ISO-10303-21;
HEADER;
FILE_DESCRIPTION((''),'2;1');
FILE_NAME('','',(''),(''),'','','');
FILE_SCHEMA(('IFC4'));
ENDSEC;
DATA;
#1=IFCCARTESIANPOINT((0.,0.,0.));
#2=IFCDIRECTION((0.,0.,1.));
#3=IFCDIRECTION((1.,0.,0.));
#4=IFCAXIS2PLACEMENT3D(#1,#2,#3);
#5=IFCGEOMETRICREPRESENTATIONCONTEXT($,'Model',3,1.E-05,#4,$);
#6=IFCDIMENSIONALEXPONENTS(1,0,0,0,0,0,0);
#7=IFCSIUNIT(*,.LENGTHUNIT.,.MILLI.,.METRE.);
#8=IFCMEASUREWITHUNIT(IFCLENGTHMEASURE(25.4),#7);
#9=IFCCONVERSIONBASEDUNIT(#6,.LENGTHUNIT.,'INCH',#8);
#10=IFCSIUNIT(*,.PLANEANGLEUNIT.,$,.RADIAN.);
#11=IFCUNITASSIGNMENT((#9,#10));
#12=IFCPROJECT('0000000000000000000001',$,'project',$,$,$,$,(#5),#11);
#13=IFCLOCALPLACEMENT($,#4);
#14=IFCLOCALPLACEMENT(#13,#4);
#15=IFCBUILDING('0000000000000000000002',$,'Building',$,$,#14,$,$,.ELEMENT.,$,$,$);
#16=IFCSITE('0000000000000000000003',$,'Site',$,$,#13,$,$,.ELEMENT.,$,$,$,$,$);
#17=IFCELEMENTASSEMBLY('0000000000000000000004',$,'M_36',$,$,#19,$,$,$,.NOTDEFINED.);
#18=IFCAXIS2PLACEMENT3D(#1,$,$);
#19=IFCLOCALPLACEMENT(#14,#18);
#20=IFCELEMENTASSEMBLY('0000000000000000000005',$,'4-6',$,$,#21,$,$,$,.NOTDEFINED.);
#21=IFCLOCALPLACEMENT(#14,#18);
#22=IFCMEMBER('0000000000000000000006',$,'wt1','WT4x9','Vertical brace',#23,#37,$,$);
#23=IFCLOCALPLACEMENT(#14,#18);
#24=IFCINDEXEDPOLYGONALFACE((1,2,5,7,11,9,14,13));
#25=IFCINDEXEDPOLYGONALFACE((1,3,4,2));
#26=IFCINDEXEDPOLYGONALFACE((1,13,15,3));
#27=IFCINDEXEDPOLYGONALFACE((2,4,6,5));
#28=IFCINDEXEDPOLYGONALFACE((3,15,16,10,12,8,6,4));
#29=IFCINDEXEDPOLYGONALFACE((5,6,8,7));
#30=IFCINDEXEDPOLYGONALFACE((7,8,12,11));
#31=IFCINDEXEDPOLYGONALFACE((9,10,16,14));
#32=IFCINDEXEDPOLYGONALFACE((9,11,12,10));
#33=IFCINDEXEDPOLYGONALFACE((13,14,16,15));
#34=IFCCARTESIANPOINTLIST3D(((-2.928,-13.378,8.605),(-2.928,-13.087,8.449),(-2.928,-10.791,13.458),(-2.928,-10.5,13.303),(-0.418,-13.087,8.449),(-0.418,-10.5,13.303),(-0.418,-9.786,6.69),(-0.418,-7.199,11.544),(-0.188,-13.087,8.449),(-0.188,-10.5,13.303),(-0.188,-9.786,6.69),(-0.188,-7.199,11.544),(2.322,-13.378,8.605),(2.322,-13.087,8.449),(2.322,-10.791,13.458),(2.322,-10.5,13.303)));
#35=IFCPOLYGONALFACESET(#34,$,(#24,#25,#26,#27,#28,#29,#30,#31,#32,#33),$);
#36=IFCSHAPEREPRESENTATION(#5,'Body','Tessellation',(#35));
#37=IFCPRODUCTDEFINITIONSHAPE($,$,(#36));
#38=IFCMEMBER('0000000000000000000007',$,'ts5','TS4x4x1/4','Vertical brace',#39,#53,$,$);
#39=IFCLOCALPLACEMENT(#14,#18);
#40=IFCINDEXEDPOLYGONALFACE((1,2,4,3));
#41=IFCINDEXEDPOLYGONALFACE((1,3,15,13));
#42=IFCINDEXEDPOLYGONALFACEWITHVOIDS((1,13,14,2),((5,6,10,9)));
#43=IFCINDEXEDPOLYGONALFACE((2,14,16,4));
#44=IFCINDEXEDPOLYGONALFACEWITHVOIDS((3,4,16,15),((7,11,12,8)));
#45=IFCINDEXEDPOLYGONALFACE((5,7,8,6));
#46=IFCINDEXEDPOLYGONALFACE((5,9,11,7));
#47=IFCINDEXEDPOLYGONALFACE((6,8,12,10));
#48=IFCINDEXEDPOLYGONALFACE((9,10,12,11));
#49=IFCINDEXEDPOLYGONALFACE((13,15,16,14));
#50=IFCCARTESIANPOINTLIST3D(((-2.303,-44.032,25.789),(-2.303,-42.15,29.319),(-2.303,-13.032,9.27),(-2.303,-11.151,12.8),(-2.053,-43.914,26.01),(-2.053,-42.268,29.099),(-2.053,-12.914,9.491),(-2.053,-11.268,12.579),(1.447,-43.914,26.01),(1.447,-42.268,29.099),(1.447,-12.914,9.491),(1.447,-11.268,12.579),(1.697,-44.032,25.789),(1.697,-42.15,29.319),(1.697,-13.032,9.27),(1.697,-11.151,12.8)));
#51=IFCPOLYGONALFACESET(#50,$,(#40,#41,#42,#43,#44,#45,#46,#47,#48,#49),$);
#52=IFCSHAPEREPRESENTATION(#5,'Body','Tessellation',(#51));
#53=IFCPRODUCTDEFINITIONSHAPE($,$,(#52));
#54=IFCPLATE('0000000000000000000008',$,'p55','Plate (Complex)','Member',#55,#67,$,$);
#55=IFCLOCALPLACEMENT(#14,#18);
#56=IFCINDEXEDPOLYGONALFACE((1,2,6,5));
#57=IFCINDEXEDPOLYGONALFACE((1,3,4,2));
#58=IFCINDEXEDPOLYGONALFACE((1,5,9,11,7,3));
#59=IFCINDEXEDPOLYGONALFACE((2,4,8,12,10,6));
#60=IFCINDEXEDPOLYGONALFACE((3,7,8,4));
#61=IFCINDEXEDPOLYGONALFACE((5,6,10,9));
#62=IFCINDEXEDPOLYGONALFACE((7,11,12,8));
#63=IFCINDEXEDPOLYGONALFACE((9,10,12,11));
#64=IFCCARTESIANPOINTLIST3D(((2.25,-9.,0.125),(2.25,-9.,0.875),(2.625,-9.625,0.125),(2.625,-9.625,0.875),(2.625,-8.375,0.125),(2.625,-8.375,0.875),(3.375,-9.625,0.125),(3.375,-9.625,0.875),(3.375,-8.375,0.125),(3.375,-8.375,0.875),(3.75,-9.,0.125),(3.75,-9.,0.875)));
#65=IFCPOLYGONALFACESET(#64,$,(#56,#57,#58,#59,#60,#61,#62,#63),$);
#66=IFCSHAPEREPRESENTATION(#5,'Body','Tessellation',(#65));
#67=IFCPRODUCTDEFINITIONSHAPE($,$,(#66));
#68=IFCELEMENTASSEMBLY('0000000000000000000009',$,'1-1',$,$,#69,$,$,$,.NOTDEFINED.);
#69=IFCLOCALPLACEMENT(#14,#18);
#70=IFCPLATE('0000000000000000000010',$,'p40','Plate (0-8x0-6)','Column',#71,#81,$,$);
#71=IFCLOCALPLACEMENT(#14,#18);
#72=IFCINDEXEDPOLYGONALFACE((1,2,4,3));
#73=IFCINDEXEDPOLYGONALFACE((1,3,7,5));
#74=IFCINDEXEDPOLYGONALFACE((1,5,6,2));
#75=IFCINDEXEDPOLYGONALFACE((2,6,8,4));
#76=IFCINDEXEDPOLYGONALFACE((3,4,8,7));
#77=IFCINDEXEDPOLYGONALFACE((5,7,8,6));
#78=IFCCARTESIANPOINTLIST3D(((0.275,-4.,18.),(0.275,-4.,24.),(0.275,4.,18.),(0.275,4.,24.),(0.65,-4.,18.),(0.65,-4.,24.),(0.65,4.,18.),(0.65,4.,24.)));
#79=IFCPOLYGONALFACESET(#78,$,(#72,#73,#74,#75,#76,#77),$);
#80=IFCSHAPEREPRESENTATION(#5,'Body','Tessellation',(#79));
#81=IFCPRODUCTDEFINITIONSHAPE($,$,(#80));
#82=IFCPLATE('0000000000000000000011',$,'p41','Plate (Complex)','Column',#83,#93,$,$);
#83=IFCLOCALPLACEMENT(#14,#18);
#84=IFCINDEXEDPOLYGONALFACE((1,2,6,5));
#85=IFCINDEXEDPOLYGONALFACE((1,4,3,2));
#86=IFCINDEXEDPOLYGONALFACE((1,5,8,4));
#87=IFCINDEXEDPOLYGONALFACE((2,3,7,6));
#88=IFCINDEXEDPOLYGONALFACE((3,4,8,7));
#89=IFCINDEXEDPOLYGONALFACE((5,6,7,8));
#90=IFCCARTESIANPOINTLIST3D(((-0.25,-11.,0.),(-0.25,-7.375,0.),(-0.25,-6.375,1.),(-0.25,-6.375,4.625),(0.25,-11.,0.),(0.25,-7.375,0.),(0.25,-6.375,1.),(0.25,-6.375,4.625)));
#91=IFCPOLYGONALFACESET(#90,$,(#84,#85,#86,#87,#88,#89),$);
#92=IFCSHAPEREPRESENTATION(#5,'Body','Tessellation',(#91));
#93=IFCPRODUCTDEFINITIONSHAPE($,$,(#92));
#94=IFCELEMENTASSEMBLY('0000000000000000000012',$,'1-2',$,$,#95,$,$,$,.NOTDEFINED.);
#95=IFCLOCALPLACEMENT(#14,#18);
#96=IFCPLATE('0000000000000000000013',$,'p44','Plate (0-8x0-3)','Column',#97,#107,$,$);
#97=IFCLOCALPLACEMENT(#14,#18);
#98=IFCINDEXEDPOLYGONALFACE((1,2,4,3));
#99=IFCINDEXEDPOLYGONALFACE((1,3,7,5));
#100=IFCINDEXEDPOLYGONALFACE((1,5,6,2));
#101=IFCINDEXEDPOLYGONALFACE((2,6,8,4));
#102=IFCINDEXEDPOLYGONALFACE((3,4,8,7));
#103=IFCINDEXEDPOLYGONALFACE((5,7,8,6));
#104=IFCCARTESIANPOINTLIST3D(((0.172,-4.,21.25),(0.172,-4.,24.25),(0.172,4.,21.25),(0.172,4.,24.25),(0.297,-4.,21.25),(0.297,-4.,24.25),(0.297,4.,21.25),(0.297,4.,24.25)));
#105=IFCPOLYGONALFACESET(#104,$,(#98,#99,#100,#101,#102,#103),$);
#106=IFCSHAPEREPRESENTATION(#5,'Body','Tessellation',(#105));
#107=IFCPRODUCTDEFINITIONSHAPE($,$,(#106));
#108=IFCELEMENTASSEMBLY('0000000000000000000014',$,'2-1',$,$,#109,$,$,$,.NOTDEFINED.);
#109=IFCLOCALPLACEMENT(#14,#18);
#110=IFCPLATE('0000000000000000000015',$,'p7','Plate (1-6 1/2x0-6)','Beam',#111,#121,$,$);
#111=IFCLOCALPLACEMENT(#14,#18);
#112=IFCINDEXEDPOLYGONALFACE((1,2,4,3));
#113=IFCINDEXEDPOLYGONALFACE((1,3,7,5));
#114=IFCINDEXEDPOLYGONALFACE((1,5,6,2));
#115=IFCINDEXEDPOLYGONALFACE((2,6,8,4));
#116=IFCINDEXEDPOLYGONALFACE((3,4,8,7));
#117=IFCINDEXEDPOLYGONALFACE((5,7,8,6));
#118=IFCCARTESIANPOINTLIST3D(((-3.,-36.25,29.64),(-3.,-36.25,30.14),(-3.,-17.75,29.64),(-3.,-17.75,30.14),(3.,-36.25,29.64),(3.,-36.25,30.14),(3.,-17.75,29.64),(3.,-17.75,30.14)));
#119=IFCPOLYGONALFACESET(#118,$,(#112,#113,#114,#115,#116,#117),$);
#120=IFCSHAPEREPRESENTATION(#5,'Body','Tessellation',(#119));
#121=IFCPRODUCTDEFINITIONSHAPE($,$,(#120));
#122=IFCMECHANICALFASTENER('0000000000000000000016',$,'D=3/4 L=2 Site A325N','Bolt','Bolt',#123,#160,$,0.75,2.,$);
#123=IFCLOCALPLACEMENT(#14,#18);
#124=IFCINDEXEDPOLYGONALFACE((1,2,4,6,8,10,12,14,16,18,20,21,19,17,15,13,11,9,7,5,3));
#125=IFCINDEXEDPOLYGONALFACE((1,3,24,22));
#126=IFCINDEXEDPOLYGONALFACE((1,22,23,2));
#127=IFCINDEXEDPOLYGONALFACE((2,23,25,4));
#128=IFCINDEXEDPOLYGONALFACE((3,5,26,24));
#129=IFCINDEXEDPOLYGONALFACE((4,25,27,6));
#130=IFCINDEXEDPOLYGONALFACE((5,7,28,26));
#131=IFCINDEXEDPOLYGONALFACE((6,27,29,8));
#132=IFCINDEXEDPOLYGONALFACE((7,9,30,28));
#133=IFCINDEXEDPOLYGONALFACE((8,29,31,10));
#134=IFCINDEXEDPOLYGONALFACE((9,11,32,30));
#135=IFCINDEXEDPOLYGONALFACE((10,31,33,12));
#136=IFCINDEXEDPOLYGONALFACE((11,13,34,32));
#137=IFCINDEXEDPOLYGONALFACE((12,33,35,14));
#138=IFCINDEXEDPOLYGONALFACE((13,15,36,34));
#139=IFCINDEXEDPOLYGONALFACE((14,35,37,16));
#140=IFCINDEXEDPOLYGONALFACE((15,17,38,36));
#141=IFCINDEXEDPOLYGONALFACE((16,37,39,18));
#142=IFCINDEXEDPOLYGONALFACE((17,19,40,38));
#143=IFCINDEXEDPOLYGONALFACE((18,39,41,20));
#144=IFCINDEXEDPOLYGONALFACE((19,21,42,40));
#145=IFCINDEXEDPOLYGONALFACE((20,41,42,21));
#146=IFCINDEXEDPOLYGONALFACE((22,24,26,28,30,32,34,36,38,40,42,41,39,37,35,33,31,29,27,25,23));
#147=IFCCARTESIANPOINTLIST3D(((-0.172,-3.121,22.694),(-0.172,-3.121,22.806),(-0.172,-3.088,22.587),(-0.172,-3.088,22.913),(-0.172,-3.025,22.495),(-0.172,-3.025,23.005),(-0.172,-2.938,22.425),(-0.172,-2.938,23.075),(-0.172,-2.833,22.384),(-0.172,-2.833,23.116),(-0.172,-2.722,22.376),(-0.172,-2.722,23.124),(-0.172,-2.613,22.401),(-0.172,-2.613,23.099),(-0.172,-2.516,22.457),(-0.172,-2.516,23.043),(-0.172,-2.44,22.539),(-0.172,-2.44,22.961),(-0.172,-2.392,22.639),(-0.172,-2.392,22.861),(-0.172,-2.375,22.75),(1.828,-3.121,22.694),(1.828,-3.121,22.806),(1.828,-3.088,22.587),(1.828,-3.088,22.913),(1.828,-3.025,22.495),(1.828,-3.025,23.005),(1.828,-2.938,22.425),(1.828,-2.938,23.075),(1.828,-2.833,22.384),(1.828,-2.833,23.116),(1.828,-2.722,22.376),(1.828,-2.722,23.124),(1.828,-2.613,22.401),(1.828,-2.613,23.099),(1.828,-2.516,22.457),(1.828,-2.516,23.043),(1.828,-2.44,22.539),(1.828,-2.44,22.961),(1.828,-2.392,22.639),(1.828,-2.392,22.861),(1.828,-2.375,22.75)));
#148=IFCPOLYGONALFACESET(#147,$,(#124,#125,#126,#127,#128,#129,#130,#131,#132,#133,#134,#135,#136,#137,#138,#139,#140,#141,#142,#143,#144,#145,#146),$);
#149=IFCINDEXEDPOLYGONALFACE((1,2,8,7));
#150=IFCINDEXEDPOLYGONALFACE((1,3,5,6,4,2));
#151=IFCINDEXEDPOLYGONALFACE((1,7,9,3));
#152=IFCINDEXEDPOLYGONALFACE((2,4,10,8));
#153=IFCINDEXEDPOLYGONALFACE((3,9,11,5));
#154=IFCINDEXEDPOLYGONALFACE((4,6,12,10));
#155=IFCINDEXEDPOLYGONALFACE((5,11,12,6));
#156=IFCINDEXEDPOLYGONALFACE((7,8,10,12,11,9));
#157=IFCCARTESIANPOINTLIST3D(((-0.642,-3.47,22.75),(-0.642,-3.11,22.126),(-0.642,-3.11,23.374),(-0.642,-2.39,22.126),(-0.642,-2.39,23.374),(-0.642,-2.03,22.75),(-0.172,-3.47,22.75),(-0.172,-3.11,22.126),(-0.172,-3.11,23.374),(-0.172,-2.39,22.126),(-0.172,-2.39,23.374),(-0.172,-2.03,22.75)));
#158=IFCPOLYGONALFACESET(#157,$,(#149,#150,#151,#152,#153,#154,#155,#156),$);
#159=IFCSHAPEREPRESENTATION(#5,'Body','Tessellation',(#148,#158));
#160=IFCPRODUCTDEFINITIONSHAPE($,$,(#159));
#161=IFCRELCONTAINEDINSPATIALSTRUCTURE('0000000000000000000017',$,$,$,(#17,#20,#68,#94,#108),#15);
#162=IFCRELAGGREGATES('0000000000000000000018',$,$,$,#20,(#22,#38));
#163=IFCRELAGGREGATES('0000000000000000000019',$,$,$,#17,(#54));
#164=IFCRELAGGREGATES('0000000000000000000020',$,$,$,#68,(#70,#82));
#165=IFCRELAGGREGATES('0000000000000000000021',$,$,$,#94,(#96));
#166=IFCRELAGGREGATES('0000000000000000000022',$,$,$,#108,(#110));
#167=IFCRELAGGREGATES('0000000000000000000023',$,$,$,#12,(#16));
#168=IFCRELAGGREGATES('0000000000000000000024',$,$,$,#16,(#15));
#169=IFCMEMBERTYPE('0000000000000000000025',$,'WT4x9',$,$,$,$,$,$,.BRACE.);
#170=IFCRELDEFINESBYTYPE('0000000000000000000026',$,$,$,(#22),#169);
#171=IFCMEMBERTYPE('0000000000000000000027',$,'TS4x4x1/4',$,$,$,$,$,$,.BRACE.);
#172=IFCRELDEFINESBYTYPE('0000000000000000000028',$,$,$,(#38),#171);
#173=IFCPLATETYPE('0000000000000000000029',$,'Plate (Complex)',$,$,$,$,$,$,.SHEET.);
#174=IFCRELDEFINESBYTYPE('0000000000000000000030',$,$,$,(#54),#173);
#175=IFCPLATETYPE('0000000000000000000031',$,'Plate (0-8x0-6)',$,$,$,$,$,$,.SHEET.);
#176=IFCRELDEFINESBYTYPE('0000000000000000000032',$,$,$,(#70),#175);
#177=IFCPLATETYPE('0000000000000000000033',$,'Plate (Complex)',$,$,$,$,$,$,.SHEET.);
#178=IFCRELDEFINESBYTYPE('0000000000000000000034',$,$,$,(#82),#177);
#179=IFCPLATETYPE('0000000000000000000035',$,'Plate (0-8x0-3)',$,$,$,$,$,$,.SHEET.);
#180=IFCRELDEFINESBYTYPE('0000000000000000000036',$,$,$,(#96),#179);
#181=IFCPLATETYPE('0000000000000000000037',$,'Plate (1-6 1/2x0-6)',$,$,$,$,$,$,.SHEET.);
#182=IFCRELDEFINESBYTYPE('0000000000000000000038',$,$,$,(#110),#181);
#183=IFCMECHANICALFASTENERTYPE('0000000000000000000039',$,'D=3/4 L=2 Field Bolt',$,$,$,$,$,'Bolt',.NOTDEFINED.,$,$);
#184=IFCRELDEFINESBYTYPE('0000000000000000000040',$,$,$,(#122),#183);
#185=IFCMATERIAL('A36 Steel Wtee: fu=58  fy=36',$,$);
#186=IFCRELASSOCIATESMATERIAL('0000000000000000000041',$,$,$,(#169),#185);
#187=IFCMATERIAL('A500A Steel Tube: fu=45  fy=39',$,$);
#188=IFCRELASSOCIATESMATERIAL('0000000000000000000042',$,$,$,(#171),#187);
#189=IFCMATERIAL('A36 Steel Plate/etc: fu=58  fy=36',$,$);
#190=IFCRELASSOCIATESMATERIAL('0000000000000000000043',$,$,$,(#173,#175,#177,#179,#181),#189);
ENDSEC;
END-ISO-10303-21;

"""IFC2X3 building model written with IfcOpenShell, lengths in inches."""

from ifc_helpers import new_model, entity, si_unit, converted_unit, frame, frame_2d, origin_with_axes, origin_2d_with_axis, place, context, project, spatial, polyline, hollow_rectangle, circle, t_section, outline, extrude, source, transform, mapped, material, type_object, type_shapes, element, aggregate, save


model = new_model("IFC2X3")

# Units and contexts
model_context = context("Model", 3, precision=1e-05, world=origin_with_axes())
ifc_project = project(units=[converted_unit("LENGTHUNIT", "INCH", entity("IfcLengthMeasure", 25.4), si_unit("LENGTHUNIT", "METRE", prefix="MILLI"), dimensions=[1, 0, 0, 0, 0, 0, 0]), si_unit("PLANEANGLEUNIT", "RADIAN")], contexts=[model_context])

# Site, building
site_placement = place(None, origin_with_axes())
site = spatial("IfcSite", under=ifc_project, at=site_placement, Name="Site", CompositionType="ELEMENT")
building_placement = place(site_placement, origin_with_axes())
building = spatial("IfcBuilding", under=site, at=building_placement, Name="Building", CompositionType="ELEMENT")

# Element assembly
assembly_1_placement = place(building_placement, frame((3.0, -9.0, -22.668), z_axis=(0.0, -1.0, 0.0), x_axis=(0.0, 0.0, 1.0)))
assembly_1 = element("IfcElementAssembly", 1, at=assembly_1_placement, inside=building, Name="M_36", PredefinedType="NOTDEFINED")

# Element assembly, members
assembly_2_placement = place(building_placement, frame((-0.303, -6.355, 7.978), z_axis=(0.0, 0.470284, 0.882515), x_axis=(0.0, -0.882515, 0.470284)))
assembly_2 = element("IfcElementAssembly", 2, at=assembly_2_placement, inside=building, Name="4-6", PredefinedType="NOTDEFINED")
ifc_material_1 = material(Name="A36 Steel Wtee: fu=58  fy=36")
member_type_1 = type_object("IfcMemberType", Name="WT4x9", PredefinedType="BRACE", material=ifc_material_1)
shared_shape_1 = source(origin_with_axes(), model_context, "Body", "SweptSolid", [
    extrude(t_section(Depth=4.07, FlangeWidth=5.25, WebThickness=0.23, FlangeThickness=0.33, at=frame_2d((0.0, -2.035), x_axis=(1.0, 0.0))), frame((0.0, 0.0, 0.0), z_axis=(1.0, 0.0, 0.0), x_axis=(0.0, 1.0, 0.0)), (0.0, 0.0, 1.0), 5.5),
])
type_shapes(member_type_1, [shared_shape_1])
member_1_placement = place(assembly_2_placement, frame((6.492, 0.0, 2.75), z_axis=(1.0, 0.0, 0.0), x_axis=(0.0, 0.0, -1.0)))
member_1 = element("IfcMember", 3, at=member_1_placement, type_object=member_type_1, Name="wt1", Description="WT4x9", ObjectType="Vertical brace", context=model_context, shape_type="MappedRepresentation", body=[
    mapped(shared_shape_1, transform((0.0, 0.0, 0.0), scale=1.0)),
])
ifc_material_2 = material(Name="A500A Steel Tube: fu=45  fy=39")
member_type_2 = type_object("IfcMemberType", Name="TS4x4x1/4", PredefinedType="BRACE", material=ifc_material_2)
shared_shape_2 = source(origin_with_axes(), model_context, "Body", "SweptSolid", [
    extrude(hollow_rectangle(XDim=4.0, YDim=4.0, WallThickness=0.25, at=origin_2d_with_axis()), frame((0.0, 0.0, 0.0), z_axis=(1.0, 0.0, 0.0), x_axis=(0.0, 1.0, 0.0)), (0.0, 0.0, 1.0), 35.126),
])
type_shapes(member_type_2, [shared_shape_2])
member_2_placement = place(assembly_2_placement, frame((6.5, 0.0, 0.0), z_axis=(0.0, 0.0, 1.0), x_axis=(1.0, 0.0, 0.0)))
member_2 = element("IfcMember", 4, at=member_2_placement, type_object=member_type_2, Name="ts5", Description="TS4x4x1/4", ObjectType="Vertical brace", context=model_context, shape_type="MappedRepresentation", body=[
    mapped(shared_shape_2, transform((0.0, 0.0, 0.0), scale=1.0)),
])
aggregate(assembly_2, [member_1, member_2])

# Plate
ifc_material_3 = material(Name="A36 Steel Plate/etc: fu=58  fy=36")
plate_type_1 = type_object("IfcPlateType", Name="Plate (Complex)", PredefinedType="SHEET", material=ifc_material_3)
shared_shape_3 = source(origin_with_axes(), model_context, "Body", "SweptSolid", [
    extrude(outline(polyline([(0.0, -1.125), (-0.625, -1.5), (-1.25, -1.125), (-1.25, -0.375), (-0.625, 0.0), (0.0, -0.375), (0.0, -1.125)])), frame((-0.375, 0.0, 0.0), z_axis=(1.0, 0.0, 0.0), x_axis=(0.0, 1.0, 0.0)), (0.0, 0.0, 1.0), 0.75),
])
type_shapes(plate_type_1, [shared_shape_3])
plate_1_placement = place(assembly_1_placement, frame((23.168, 0.75, -0.625), z_axis=(0.0, 1.0, 0.0), x_axis=(1.0, 0.0, 0.0)))
plate_1 = element("IfcPlate", 5, at=plate_1_placement, type_object=plate_type_1, Name="p55", Description="Plate (Complex)", ObjectType="Member", context=model_context, shape_type="MappedRepresentation", body=[
    mapped(shared_shape_3, transform((0.0, 0.0, 0.0), scale=1.0)),
])
aggregate(assembly_1, [plate_1])

# Element assembly, plates
assembly_3_placement = place(building_placement, frame((0.0, 0.0, -1.5), z_axis=(0.0, -1.0, 0.0), x_axis=(0.0, 0.0, 1.0)))
assembly_3 = element("IfcElementAssembly", 6, at=assembly_3_placement, inside=building, Name="1-1", PredefinedType="NOTDEFINED")
plate_type_2 = type_object("IfcPlateType", Name="Plate (0-8x0-6)", PredefinedType="SHEET", material=ifc_material_3)
shared_shape_4 = source(origin_with_axes(), model_context, "Body", "SweptSolid", [
    extrude(outline(polyline([(0.0, -8.0), (-6.0, -8.0), (-6.0, 0.0), (0.0, 0.0), (0.0, -8.0)])), frame((-0.188, 0.0, 0.0), z_axis=(1.0, 0.0, 0.0), x_axis=(0.0, 1.0, 0.0)), (0.0, 0.0, 1.0), 0.375),
])
type_shapes(plate_type_2, [shared_shape_4])
plate_2_placement = place(assembly_3_placement, frame((25.5, -0.463, 4.0), z_axis=(0.0, 0.0, 1.0), x_axis=(0.0, -1.0, 0.0)))
plate_2 = element("IfcPlate", 7, at=plate_2_placement, type_object=plate_type_2, Name="p40", Description="Plate (0-8x0-6)", ObjectType="Column", context=model_context, shape_type="MappedRepresentation", body=[
    mapped(shared_shape_4, transform((0.0, 0.0, 0.0), scale=1.0)),
])
plate_type_3 = type_object("IfcPlateType", Name="Plate (Complex)", PredefinedType="SHEET", material=ifc_material_3)
shared_shape_5 = source(origin_with_axes(), model_context, "Body", "SweptSolid", [
    extrude(outline(polyline([(-4.625, -4.625), (-4.625, -1.0), (-3.625, 0.0), (0.0, 0.0), (-4.625, -4.625)])), frame((-0.25, 0.0, 0.0), z_axis=(1.0, 0.0, 0.0), x_axis=(0.0, 1.0, 0.0)), (0.0, 0.0, 1.0), 0.5),
])
type_shapes(plate_type_3, [shared_shape_5])
plate_3_placement = place(assembly_3_placement, frame((6.125, 0.0, 6.375), z_axis=(0.0, 0.0, -1.0), x_axis=(0.0, 1.0, 0.0)))
plate_3 = element("IfcPlate", 8, at=plate_3_placement, type_object=plate_type_3, Name="p41", Description="Plate (Complex)", ObjectType="Column", context=model_context, shape_type="MappedRepresentation", body=[
    mapped(shared_shape_5, transform((0.0, 0.0, 0.0), scale=1.0)),
])
aggregate(assembly_3, [plate_2, plate_3])

# Element assemblies, plates
assembly_4_placement = place(building_placement, frame((0.0, 0.0, 21.0), z_axis=(0.0, -1.0, 0.0), x_axis=(0.0, 0.0, 1.0)))
assembly_4 = element("IfcElementAssembly", 9, at=assembly_4_placement, inside=building, Name="1-2", PredefinedType="NOTDEFINED")
plate_type_4 = type_object("IfcPlateType", Name="Plate (0-8x0-3)", PredefinedType="SHEET", material=ifc_material_3)
shared_shape_6 = source(origin_with_axes(), model_context, "Body", "SweptSolid", [
    extrude(outline(polyline([(0.0, -8.0), (-3.0, -8.0), (-3.0, 0.0), (0.0, 0.0), (0.0, -8.0)])), frame((-0.062, 0.0, 0.0), z_axis=(1.0, 0.0, 0.0), x_axis=(0.0, 1.0, 0.0)), (0.0, 0.0, 1.0), 0.125),
])
type_shapes(plate_type_4, [shared_shape_6])
plate_4_placement = place(assembly_4_placement, frame((3.25, -0.235, 4.0), z_axis=(0.0, 0.0, 1.0), x_axis=(0.0, -1.0, 0.0)))
plate_4 = element("IfcPlate", 10, at=plate_4_placement, type_object=plate_type_4, Name="p44", Description="Plate (0-8x0-3)", ObjectType="Column", context=model_context, shape_type="MappedRepresentation", body=[
    mapped(shared_shape_6, transform((0.0, 0.0, 0.0), scale=1.0)),
])
aggregate(assembly_4, [plate_4])
assembly_5_placement = place(building_placement, frame((0.0, 0.0, 46.0), z_axis=(0.0, 0.0, 1.0), x_axis=(0.0, -1.0, 0.0)))
assembly_5 = element("IfcElementAssembly", 11, at=assembly_5_placement, inside=building, Name="2-1", PredefinedType="NOTDEFINED")
plate_type_5 = type_object("IfcPlateType", Name="Plate (1-6 1/2x0-6)", PredefinedType="SHEET", material=ifc_material_3)
shared_shape_7 = source(origin_with_axes(), model_context, "Body", "SweptSolid", [
    extrude(outline(polyline([(3.0, -18.5), (-3.0, -18.5), (-3.0, 0.0), (3.0, 0.0), (3.0, -18.5)])), frame((-0.25, 0.0, 0.0), z_axis=(1.0, 0.0, 0.0), x_axis=(0.0, 1.0, 0.0)), (0.0, 0.0, 1.0), 0.5),
])
type_shapes(plate_type_5, [shared_shape_7])
plate_5_placement = place(assembly_5_placement, frame((36.25, 0.0, -16.11), z_axis=(1.0, 0.0, 0.0), x_axis=(0.0, 0.0, -1.0)))
plate_5 = element("IfcPlate", 12, at=plate_5_placement, type_object=plate_type_5, Name="p7", Description="Plate (1-6 1/2x0-6)", ObjectType="Beam", context=model_context, shape_type="MappedRepresentation", body=[
    mapped(shared_shape_7, transform((0.0, 0.0, 0.0), scale=1.0)),
])
aggregate(assembly_5, [plate_5])

# Mechanical fastener
mechanical_fastener_type_1 = type_object("IfcMechanicalFastenerType", Name="D=3/4 L=2 Field Bolt", ElementType="Bolt")
shared_shape_8 = source(origin_with_axes(), model_context, "Body", "SweptSolid", [
    extrude(circle(Radius=0.375, at=origin_2d_with_axis()), frame((0.0, 0.0, 0.0), z_axis=(1.0, 0.0, 0.0), x_axis=(0.0, 1.0, 0.0)), (0.0, 0.0, 1.0), 2.0),
    extrude(outline(polyline([(-0.72, 0.0), (-0.36, 0.624), (0.36, 0.624), (0.72, 0.0), (0.36, -0.624), (-0.36, -0.624), (-0.72, 0.0)])), frame((0.0, 0.0, 0.0), z_axis=(1.0, 0.0, 0.0), x_axis=(0.0, 1.0, 0.0)), (0.0, 0.0, -1.0), 0.47),
])
type_shapes(mechanical_fastener_type_1, [shared_shape_8])
placement_1 = place(assembly_4_placement, frame((1.75, 0.172, -2.75), z_axis=(1.0, 0.0, 0.0), x_axis=(0.0, -1.0, 0.0)))
mechanical_fastener_1_placement = place(placement_1, frame((0.0, -5.5, 0.0), z_axis=(0.0, 0.0, 1.0), x_axis=(1.0, 0.0, 0.0)))
element("IfcMechanicalFastener", 13, at=mechanical_fastener_1_placement, type_object=mechanical_fastener_type_1, Name="D=3/4 L=2 Site A325N", Description="Bolt", ObjectType="Bolt", NominalDiameter=0.75, NominalLength=2.0, context=model_context, shape_type="MappedRepresentation", body=[
    mapped(shared_shape_8, transform((0.0, 0.0, 0.0), scale=1.0)),
])

save(model, "model.ifc")
